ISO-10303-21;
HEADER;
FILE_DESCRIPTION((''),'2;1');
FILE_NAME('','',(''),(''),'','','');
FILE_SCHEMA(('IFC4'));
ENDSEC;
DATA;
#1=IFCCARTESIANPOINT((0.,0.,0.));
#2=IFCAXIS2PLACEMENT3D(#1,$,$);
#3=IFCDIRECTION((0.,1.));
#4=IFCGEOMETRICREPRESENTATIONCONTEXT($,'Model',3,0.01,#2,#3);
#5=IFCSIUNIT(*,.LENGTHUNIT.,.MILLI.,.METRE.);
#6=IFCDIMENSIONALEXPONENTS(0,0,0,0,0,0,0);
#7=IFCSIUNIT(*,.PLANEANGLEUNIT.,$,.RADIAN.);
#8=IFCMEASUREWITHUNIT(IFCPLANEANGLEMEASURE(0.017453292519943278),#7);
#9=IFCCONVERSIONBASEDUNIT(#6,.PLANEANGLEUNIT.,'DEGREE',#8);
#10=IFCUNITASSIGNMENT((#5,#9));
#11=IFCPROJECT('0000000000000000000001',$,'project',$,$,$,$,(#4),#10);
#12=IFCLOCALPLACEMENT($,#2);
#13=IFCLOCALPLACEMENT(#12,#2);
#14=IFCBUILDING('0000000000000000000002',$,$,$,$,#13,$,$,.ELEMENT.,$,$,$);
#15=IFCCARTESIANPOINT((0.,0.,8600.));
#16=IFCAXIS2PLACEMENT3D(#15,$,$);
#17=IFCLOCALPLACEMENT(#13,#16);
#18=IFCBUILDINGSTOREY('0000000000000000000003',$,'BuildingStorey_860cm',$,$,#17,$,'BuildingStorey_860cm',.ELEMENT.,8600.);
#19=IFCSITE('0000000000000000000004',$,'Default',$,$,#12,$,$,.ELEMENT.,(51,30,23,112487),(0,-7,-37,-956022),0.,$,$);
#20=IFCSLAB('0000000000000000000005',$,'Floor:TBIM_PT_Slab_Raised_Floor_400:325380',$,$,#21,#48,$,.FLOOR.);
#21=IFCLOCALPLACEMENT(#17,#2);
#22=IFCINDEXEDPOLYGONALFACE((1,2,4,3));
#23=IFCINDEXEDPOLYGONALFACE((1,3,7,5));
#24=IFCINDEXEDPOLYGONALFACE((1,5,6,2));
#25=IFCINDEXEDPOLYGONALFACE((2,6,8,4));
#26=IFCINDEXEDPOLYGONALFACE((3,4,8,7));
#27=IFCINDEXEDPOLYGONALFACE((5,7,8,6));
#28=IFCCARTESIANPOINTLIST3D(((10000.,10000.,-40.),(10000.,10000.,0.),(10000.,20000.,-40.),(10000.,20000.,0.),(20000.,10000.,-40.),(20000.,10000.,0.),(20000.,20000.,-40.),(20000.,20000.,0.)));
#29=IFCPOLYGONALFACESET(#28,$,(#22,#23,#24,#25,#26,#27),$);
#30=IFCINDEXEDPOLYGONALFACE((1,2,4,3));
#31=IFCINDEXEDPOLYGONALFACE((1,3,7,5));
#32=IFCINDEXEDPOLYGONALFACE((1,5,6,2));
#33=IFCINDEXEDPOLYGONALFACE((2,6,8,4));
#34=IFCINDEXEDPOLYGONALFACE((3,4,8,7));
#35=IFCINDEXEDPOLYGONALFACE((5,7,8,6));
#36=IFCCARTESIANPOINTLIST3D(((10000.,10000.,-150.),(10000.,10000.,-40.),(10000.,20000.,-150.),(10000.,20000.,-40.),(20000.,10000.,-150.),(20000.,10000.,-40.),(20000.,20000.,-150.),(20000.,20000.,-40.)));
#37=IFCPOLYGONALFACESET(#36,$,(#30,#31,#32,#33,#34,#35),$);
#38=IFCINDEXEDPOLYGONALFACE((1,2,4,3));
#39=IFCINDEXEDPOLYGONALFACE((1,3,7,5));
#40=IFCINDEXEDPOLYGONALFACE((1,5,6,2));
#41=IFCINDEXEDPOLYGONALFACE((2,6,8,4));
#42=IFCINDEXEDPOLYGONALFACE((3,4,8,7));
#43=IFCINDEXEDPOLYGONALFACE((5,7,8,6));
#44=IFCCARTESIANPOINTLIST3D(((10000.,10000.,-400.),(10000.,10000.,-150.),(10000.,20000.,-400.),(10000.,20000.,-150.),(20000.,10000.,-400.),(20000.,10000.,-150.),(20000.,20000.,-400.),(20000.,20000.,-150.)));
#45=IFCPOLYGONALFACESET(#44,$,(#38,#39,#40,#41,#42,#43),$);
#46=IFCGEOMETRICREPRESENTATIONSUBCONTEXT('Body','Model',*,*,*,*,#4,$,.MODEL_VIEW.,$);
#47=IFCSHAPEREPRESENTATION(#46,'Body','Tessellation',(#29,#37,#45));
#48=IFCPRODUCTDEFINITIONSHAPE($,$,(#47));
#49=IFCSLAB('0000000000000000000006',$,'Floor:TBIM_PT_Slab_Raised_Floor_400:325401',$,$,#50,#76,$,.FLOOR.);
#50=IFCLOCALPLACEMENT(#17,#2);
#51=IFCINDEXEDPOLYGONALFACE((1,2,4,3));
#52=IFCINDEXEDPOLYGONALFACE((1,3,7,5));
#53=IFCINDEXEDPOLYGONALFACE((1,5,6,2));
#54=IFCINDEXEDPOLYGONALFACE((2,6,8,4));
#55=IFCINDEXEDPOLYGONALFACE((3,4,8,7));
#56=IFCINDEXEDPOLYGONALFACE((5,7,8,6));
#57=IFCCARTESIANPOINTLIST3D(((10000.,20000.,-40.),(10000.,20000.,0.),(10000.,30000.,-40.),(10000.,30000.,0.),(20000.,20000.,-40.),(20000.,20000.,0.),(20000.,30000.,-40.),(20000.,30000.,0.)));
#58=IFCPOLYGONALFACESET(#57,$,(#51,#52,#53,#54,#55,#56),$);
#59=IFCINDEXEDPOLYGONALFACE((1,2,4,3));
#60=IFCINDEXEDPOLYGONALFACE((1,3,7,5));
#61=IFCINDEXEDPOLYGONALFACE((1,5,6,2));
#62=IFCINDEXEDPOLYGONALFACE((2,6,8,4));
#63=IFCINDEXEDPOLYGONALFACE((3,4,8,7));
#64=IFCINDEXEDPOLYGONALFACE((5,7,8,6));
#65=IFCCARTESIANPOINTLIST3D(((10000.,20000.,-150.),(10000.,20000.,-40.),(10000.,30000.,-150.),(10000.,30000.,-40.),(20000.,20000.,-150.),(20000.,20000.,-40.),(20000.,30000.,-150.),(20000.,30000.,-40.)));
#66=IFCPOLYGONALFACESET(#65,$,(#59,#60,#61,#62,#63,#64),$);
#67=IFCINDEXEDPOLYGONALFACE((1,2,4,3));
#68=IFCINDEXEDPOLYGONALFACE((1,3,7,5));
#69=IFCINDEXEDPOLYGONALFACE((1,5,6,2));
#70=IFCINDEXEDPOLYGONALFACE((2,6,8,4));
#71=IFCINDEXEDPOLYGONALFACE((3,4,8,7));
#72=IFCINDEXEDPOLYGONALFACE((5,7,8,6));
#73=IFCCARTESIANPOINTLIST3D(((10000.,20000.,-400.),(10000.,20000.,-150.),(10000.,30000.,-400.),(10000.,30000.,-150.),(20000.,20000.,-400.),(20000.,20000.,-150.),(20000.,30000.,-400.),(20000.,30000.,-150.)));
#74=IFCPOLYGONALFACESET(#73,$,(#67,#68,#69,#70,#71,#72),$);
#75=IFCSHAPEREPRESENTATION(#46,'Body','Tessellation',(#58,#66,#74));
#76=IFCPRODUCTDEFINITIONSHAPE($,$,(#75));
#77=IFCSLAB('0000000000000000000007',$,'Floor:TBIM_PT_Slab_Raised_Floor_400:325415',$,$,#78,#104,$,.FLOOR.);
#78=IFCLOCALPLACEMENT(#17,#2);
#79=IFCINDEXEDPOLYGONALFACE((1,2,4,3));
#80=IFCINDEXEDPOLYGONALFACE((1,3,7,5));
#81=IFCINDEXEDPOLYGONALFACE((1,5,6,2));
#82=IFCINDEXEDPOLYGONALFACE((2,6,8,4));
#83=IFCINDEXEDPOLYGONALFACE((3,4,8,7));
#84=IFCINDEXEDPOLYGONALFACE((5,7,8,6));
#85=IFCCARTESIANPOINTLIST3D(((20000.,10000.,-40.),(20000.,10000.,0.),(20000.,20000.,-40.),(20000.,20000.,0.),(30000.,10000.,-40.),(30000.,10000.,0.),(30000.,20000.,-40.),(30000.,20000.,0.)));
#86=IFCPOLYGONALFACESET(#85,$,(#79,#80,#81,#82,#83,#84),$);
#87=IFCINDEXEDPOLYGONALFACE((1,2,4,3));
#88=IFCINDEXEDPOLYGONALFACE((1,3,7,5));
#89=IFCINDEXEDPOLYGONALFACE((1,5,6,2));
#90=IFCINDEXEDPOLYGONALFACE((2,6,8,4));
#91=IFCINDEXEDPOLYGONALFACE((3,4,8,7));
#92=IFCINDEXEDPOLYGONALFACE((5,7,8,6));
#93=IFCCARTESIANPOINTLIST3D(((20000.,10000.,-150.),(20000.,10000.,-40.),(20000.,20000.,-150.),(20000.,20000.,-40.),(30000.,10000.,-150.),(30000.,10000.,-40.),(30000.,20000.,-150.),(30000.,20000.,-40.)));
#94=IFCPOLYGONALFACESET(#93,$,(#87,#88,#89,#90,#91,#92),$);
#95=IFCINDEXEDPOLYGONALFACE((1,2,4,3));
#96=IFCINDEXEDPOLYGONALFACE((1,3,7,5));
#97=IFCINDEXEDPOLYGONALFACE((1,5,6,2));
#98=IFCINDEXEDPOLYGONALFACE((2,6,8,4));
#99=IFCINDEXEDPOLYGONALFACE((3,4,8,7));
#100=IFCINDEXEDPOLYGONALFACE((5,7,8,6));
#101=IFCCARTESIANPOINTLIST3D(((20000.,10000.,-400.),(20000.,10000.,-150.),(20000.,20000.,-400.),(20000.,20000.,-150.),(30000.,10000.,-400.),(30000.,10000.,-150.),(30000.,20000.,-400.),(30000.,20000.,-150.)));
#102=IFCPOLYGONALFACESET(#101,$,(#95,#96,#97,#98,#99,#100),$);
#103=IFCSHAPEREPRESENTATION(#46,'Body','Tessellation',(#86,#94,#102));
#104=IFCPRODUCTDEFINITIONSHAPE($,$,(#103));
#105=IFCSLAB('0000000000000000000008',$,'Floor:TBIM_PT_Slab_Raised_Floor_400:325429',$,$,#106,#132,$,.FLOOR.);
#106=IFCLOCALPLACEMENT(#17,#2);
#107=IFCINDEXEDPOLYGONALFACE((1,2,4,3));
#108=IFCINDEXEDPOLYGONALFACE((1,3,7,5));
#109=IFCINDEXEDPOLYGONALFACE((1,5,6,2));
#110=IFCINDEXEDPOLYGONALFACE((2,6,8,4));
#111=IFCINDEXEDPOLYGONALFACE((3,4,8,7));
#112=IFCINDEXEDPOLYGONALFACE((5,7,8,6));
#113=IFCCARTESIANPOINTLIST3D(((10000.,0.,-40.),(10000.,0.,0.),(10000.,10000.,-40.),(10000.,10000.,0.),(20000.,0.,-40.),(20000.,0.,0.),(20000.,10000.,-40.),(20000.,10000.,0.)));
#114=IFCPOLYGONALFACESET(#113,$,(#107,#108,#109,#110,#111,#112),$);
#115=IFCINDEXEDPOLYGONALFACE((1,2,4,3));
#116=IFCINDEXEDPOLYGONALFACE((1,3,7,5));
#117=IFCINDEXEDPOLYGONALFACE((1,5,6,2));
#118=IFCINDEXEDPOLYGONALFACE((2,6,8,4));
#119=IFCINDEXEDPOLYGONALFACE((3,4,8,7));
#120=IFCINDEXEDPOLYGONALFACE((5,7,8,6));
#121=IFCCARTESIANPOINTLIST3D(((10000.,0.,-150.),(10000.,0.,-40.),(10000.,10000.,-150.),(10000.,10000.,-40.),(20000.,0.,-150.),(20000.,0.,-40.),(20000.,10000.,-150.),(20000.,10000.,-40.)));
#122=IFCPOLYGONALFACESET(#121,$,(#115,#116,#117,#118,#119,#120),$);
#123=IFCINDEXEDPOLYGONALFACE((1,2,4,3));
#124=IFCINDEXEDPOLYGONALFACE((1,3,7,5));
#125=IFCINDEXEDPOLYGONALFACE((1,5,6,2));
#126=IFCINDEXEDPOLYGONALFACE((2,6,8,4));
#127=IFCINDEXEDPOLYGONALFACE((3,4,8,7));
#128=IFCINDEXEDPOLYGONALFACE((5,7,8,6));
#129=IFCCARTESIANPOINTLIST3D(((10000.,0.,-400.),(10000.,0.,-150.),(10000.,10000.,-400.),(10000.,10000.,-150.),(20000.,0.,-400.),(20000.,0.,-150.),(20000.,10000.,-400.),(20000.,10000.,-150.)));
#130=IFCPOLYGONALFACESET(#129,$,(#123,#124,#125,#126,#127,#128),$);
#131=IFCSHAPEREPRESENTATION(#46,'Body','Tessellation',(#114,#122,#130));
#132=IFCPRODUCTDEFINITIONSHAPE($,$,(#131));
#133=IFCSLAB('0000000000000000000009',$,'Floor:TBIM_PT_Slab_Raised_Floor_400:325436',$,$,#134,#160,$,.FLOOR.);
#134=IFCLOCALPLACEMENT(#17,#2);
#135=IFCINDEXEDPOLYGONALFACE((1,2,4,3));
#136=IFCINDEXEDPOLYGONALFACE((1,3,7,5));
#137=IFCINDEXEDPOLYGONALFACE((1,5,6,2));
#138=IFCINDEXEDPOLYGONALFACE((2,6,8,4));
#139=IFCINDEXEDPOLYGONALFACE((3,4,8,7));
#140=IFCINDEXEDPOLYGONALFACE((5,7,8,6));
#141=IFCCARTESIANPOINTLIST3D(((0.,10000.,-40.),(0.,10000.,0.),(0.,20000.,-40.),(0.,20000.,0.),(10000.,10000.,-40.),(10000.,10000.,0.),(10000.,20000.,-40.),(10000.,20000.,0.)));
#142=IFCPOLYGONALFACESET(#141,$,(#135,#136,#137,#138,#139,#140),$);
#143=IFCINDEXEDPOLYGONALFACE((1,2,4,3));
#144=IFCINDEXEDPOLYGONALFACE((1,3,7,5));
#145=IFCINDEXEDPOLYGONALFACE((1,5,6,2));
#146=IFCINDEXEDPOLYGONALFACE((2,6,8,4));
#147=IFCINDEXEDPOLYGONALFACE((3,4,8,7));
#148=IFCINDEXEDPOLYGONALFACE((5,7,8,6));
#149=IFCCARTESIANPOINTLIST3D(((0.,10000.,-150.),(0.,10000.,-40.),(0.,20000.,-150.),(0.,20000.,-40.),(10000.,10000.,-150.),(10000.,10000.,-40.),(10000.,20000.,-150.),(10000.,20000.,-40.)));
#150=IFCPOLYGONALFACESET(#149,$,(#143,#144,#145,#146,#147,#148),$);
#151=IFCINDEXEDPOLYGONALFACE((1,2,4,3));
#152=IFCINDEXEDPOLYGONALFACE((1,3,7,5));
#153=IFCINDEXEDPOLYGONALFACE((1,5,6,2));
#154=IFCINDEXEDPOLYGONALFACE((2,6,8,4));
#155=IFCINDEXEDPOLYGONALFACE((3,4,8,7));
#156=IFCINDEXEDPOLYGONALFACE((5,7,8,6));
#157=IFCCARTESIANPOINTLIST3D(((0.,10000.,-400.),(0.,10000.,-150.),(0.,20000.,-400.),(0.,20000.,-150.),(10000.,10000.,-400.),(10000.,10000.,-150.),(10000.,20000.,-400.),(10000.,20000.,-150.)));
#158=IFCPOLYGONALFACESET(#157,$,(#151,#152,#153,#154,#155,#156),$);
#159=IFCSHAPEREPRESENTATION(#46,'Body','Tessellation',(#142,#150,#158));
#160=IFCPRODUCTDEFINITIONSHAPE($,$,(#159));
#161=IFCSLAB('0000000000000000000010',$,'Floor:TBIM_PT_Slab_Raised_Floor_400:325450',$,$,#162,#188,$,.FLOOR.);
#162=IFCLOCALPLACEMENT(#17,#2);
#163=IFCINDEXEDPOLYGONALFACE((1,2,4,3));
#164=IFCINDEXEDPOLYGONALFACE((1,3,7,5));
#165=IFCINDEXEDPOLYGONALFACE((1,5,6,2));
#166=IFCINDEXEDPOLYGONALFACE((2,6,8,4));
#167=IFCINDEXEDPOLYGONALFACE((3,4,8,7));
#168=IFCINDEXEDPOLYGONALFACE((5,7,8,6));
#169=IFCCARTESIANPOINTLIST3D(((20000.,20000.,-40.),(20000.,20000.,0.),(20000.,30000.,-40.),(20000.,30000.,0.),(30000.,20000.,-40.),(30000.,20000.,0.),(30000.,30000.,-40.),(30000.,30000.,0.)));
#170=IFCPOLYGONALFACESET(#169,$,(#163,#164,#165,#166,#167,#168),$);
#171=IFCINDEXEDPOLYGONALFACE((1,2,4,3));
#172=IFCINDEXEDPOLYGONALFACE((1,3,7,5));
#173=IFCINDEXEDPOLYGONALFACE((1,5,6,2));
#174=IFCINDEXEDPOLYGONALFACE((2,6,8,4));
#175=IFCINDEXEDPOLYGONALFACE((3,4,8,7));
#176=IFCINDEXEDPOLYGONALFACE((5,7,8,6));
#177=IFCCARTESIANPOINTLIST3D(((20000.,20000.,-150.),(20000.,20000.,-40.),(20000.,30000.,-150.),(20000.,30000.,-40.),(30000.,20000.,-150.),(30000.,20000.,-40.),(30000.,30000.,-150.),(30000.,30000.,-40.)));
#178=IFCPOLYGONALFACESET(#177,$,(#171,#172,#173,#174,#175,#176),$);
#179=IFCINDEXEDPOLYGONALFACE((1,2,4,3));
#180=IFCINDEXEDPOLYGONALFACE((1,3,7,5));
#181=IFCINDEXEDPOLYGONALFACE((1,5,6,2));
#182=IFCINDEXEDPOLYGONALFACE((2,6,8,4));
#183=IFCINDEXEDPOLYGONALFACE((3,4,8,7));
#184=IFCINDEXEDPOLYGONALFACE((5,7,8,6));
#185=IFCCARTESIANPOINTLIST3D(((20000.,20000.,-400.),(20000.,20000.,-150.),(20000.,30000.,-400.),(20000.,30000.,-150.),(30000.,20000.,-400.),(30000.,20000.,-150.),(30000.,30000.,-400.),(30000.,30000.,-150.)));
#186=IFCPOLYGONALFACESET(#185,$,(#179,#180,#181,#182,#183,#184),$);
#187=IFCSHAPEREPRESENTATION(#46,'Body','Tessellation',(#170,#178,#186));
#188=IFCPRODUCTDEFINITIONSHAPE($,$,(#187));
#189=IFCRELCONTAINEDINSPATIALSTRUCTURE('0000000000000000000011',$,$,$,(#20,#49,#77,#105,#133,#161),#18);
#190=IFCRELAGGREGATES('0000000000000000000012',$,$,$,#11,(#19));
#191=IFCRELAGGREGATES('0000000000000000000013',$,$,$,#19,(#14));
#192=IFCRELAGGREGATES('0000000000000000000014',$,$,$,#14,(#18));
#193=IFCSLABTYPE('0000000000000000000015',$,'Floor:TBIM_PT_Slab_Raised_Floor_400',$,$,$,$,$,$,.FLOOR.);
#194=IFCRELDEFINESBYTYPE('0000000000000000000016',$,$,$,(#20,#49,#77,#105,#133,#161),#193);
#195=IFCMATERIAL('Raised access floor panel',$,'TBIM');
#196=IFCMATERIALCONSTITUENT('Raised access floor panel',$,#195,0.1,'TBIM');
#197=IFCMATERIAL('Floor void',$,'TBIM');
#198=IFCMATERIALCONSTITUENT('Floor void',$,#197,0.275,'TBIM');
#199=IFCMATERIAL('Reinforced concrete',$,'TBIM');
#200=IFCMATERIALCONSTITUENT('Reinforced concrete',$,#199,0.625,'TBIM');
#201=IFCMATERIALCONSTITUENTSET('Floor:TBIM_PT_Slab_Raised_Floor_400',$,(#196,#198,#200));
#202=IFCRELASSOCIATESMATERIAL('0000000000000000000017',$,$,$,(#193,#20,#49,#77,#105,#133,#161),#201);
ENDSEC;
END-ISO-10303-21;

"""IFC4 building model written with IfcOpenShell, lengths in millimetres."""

from ifc_helpers import new_model, entity, si_unit, converted_unit, direction, frame, origin, place, context, subcontext, project, spatial, indexed_curve, outline, extrude, material, constituent, constituent_set, type_object, element, save


model = new_model("IFC4")

# Units and contexts
model_context = context("Model", 3, precision=0.01, world=origin(), true_north=direction((0.0, 1.0)))
body_context = subcontext(model_context, "Body", "Model", "MODEL_VIEW")
ifc_project = project(units=[si_unit("LENGTHUNIT", "METRE", prefix="MILLI"), converted_unit("PLANEANGLEUNIT", "DEGREE", entity("IfcPlaneAngleMeasure", 0.017453292519943278), si_unit("PLANEANGLEUNIT", "RADIAN"), dimensions=[0, 0, 0, 0, 0, 0, 0])], contexts=[model_context])

# Site, building, storey
site_placement = place(None, origin())
site = spatial("IfcSite", under=ifc_project, at=site_placement, Name="Default", CompositionType="ELEMENT", RefLatitude=(51, 30, 23, 112487), RefLongitude=(0, -7, -37, -956022), RefElevation=0.0)
building_placement = place(site_placement, origin())
building = spatial("IfcBuilding", under=site, at=building_placement, CompositionType="ELEMENT")
storey_placement = place(building_placement, frame((0.0, 0.0, 8600.0)))
storey = spatial("IfcBuildingStorey", under=building, at=storey_placement, Name="BuildingStorey_860cm", LongName="BuildingStorey_860cm", CompositionType="ELEMENT", Elevation=8600.0)

# Slabs
ifc_material_1 = material(Name="Raised access floor panel", Category="TBIM")
ifc_constituent_1 = constituent(ifc_material_1, Name="Raised access floor panel", Category="TBIM", fraction=0.1)
ifc_material_2 = material(Name="Floor void", Category="TBIM")
ifc_constituent_2 = constituent(ifc_material_2, Name="Floor void", Category="TBIM", fraction=0.275)
ifc_material_3 = material(Name="Reinforced concrete", Category="TBIM")
ifc_constituent_3 = constituent(ifc_material_3, Name="Reinforced concrete", Category="TBIM", fraction=0.625)
ifc_constituent_set_1 = constituent_set(constituents=[ifc_constituent_1, ifc_constituent_2, ifc_constituent_3], Name="Floor:TBIM_PT_Slab_Raised_Floor_400")
slab_type = type_object("IfcSlabType", Name="Floor:TBIM_PT_Slab_Raised_Floor_400", PredefinedType="FLOOR", material=ifc_constituent_set_1)
slab_1_placement = place(storey_placement, origin())
element("IfcSlab", 1, at=slab_1_placement, inside=storey, type_object=slab_type, material=ifc_constituent_set_1, Name="Floor:TBIM_PT_Slab_Raised_Floor_400:325380", PredefinedType="FLOOR", context=body_context, shape_type="SweptSolid", body=[
    extrude(outline(indexed_curve([(-5000.0, -5000.0), (5000.0, -5000.0), (5000.0, 5000.0), (-5000.0, 5000.0), (-5000.0, -5000.0)], self_intersect=False)), frame((15000.0, 15000.0, -40.0), z_axis=(0.0, 0.0, 1.0), x_axis=(-1.0, 0.0, 0.0)), (0.0, 0.0, 1.0), 40.0),
    extrude(outline(indexed_curve([(-5000.0, -5000.0), (5000.0, -5000.0), (5000.0, 5000.0), (-5000.0, 5000.0), (-5000.0, -5000.0)], self_intersect=False)), frame((15000.0, 15000.0, -150.0), z_axis=(0.0, 0.0, 1.0), x_axis=(-1.0, 0.0, 0.0)), (0.0, 0.0, 1.0), 110.0),
    extrude(outline(indexed_curve([(-5000.0, -5000.0), (5000.0, -5000.0), (5000.0, 5000.0), (-5000.0, 5000.0), (-5000.0, -5000.0)], self_intersect=False)), frame((15000.0, 15000.0, -400.0), z_axis=(0.0, 0.0, 1.0), x_axis=(-1.0, 0.0, 0.0)), (0.0, 0.0, 1.0), 250.0),
])
slab_2_placement = place(storey_placement, origin())
element("IfcSlab", 2, at=slab_2_placement, inside=storey, type_object=slab_type, material=ifc_constituent_set_1, Name="Floor:TBIM_PT_Slab_Raised_Floor_400:325401", PredefinedType="FLOOR", context=body_context, shape_type="SweptSolid", body=[
    extrude(outline(indexed_curve([(-5000.0, -5000.0), (5000.0, -5000.0), (5000.0, 5000.0), (-5000.0, 5000.0), (-5000.0, -5000.0)], self_intersect=False)), frame((15000.0, 25000.0, -40.0), z_axis=(0.0, 0.0, 1.0), x_axis=(-1.0, 0.0, 0.0)), (0.0, 0.0, 1.0), 40.0),
    extrude(outline(indexed_curve([(-5000.0, -5000.0), (5000.0, -5000.0), (5000.0, 5000.0), (-5000.0, 5000.0), (-5000.0, -5000.0)], self_intersect=False)), frame((15000.0, 25000.0, -150.0), z_axis=(0.0, 0.0, 1.0), x_axis=(-1.0, 0.0, 0.0)), (0.0, 0.0, 1.0), 110.0),
    extrude(outline(indexed_curve([(-5000.0, -5000.0), (5000.0, -5000.0), (5000.0, 5000.0), (-5000.0, 5000.0), (-5000.0, -5000.0)], self_intersect=False)), frame((15000.0, 25000.0, -400.0), z_axis=(0.0, 0.0, 1.0), x_axis=(-1.0, 0.0, 0.0)), (0.0, 0.0, 1.0), 250.0),
])
slab_3_placement = place(storey_placement, origin())
element("IfcSlab", 3, at=slab_3_placement, inside=storey, type_object=slab_type, material=ifc_constituent_set_1, Name="Floor:TBIM_PT_Slab_Raised_Floor_400:325415", PredefinedType="FLOOR", context=body_context, shape_type="SweptSolid", body=[
    extrude(outline(indexed_curve([(-5000.0, -5000.0), (5000.0, -5000.0), (5000.0, 5000.0), (-5000.0, 5000.0), (-5000.0, -5000.0)], self_intersect=False)), frame((25000.0, 15000.0, -40.0), z_axis=(0.0, 0.0, 1.0), x_axis=(-1.0, 0.0, 0.0)), (0.0, 0.0, 1.0), 40.0),
    extrude(outline(indexed_curve([(-5000.0, -5000.0), (5000.0, -5000.0), (5000.0, 5000.0), (-5000.0, 5000.0), (-5000.0, -5000.0)], self_intersect=False)), frame((25000.0, 15000.0, -150.0), z_axis=(0.0, 0.0, 1.0), x_axis=(-1.0, 0.0, 0.0)), (0.0, 0.0, 1.0), 110.0),
    extrude(outline(indexed_curve([(-5000.0, -5000.0), (5000.0, -5000.0), (5000.0, 5000.0), (-5000.0, 5000.0), (-5000.0, -5000.0)], self_intersect=False)), frame((25000.0, 15000.0, -400.0), z_axis=(0.0, 0.0, 1.0), x_axis=(-1.0, 0.0, 0.0)), (0.0, 0.0, 1.0), 250.0),
])
slab_4_placement = place(storey_placement, origin())
element("IfcSlab", 4, at=slab_4_placement, inside=storey, type_object=slab_type, material=ifc_constituent_set_1, Name="Floor:TBIM_PT_Slab_Raised_Floor_400:325429", PredefinedType="FLOOR", context=body_context, shape_type="SweptSolid", body=[
    extrude(outline(indexed_curve([(-5000.0, -5000.0), (5000.0, -5000.0), (5000.0, 5000.0), (-5000.0, 5000.0), (-5000.0, -5000.0)], self_intersect=False)), frame((15000.0, 5000.0, -40.0), z_axis=(0.0, 0.0, 1.0), x_axis=(0.0, 1.0, 0.0)), (0.0, 0.0, 1.0), 40.0),
    extrude(outline(indexed_curve([(-5000.0, -5000.0), (5000.0, -5000.0), (5000.0, 5000.0), (-5000.0, 5000.0), (-5000.0, -5000.0)], self_intersect=False)), frame((15000.0, 5000.0, -150.0), z_axis=(0.0, 0.0, 1.0), x_axis=(0.0, 1.0, 0.0)), (0.0, 0.0, 1.0), 110.0),
    extrude(outline(indexed_curve([(-5000.0, -5000.0), (5000.0, -5000.0), (5000.0, 5000.0), (-5000.0, 5000.0), (-5000.0, -5000.0)], self_intersect=False)), frame((15000.0, 5000.0, -400.0), z_axis=(0.0, 0.0, 1.0), x_axis=(0.0, 1.0, 0.0)), (0.0, 0.0, 1.0), 250.0),
])
slab_5_placement = place(storey_placement, origin())
element("IfcSlab", 5, at=slab_5_placement, inside=storey, type_object=slab_type, material=ifc_constituent_set_1, Name="Floor:TBIM_PT_Slab_Raised_Floor_400:325436", PredefinedType="FLOOR", context=body_context, shape_type="SweptSolid", body=[
    extrude(outline(indexed_curve([(-5000.0, -5000.0), (5000.0, -5000.0), (5000.0, 5000.0), (-5000.0, 5000.0), (-5000.0, -5000.0)], self_intersect=False)), frame((5000.0, 15000.0, -40.0), z_axis=(0.0, 0.0, 1.0), x_axis=(0.0, 1.0, 0.0)), (0.0, 0.0, 1.0), 40.0),
    extrude(outline(indexed_curve([(-5000.0, -5000.0), (5000.0, -5000.0), (5000.0, 5000.0), (-5000.0, 5000.0), (-5000.0, -5000.0)], self_intersect=False)), frame((5000.0, 15000.0, -150.0), z_axis=(0.0, 0.0, 1.0), x_axis=(0.0, 1.0, 0.0)), (0.0, 0.0, 1.0), 110.0),
    extrude(outline(indexed_curve([(-5000.0, -5000.0), (5000.0, -5000.0), (5000.0, 5000.0), (-5000.0, 5000.0), (-5000.0, -5000.0)], self_intersect=False)), frame((5000.0, 15000.0, -400.0), z_axis=(0.0, 0.0, 1.0), x_axis=(0.0, 1.0, 0.0)), (0.0, 0.0, 1.0), 250.0),
])
slab_6_placement = place(storey_placement, origin())
element("IfcSlab", 6, at=slab_6_placement, inside=storey, type_object=slab_type, material=ifc_constituent_set_1, Name="Floor:TBIM_PT_Slab_Raised_Floor_400:325450", PredefinedType="FLOOR", context=body_context, shape_type="SweptSolid", body=[
    extrude(outline(indexed_curve([(-5000.0, -5000.0), (5000.0, -5000.0), (5000.0, 5000.0), (-5000.0, 5000.0), (-5000.0, -5000.0)], self_intersect=False)), frame((25000.0, 25000.0, -40.0), z_axis=(0.0, 0.0, 1.0), x_axis=(-1.0, 0.0, 0.0)), (0.0, 0.0, 1.0), 40.0),
    extrude(outline(indexed_curve([(-5000.0, -5000.0), (5000.0, -5000.0), (5000.0, 5000.0), (-5000.0, 5000.0), (-5000.0, -5000.0)], self_intersect=False)), frame((25000.0, 25000.0, -150.0), z_axis=(0.0, 0.0, 1.0), x_axis=(-1.0, 0.0, 0.0)), (0.0, 0.0, 1.0), 110.0),
    extrude(outline(indexed_curve([(-5000.0, -5000.0), (5000.0, -5000.0), (5000.0, 5000.0), (-5000.0, 5000.0), (-5000.0, -5000.0)], self_intersect=False)), frame((25000.0, 25000.0, -400.0), z_axis=(0.0, 0.0, 1.0), x_axis=(-1.0, 0.0, 0.0)), (0.0, 0.0, 1.0), 250.0),
])

save(model, "model.ifc")
